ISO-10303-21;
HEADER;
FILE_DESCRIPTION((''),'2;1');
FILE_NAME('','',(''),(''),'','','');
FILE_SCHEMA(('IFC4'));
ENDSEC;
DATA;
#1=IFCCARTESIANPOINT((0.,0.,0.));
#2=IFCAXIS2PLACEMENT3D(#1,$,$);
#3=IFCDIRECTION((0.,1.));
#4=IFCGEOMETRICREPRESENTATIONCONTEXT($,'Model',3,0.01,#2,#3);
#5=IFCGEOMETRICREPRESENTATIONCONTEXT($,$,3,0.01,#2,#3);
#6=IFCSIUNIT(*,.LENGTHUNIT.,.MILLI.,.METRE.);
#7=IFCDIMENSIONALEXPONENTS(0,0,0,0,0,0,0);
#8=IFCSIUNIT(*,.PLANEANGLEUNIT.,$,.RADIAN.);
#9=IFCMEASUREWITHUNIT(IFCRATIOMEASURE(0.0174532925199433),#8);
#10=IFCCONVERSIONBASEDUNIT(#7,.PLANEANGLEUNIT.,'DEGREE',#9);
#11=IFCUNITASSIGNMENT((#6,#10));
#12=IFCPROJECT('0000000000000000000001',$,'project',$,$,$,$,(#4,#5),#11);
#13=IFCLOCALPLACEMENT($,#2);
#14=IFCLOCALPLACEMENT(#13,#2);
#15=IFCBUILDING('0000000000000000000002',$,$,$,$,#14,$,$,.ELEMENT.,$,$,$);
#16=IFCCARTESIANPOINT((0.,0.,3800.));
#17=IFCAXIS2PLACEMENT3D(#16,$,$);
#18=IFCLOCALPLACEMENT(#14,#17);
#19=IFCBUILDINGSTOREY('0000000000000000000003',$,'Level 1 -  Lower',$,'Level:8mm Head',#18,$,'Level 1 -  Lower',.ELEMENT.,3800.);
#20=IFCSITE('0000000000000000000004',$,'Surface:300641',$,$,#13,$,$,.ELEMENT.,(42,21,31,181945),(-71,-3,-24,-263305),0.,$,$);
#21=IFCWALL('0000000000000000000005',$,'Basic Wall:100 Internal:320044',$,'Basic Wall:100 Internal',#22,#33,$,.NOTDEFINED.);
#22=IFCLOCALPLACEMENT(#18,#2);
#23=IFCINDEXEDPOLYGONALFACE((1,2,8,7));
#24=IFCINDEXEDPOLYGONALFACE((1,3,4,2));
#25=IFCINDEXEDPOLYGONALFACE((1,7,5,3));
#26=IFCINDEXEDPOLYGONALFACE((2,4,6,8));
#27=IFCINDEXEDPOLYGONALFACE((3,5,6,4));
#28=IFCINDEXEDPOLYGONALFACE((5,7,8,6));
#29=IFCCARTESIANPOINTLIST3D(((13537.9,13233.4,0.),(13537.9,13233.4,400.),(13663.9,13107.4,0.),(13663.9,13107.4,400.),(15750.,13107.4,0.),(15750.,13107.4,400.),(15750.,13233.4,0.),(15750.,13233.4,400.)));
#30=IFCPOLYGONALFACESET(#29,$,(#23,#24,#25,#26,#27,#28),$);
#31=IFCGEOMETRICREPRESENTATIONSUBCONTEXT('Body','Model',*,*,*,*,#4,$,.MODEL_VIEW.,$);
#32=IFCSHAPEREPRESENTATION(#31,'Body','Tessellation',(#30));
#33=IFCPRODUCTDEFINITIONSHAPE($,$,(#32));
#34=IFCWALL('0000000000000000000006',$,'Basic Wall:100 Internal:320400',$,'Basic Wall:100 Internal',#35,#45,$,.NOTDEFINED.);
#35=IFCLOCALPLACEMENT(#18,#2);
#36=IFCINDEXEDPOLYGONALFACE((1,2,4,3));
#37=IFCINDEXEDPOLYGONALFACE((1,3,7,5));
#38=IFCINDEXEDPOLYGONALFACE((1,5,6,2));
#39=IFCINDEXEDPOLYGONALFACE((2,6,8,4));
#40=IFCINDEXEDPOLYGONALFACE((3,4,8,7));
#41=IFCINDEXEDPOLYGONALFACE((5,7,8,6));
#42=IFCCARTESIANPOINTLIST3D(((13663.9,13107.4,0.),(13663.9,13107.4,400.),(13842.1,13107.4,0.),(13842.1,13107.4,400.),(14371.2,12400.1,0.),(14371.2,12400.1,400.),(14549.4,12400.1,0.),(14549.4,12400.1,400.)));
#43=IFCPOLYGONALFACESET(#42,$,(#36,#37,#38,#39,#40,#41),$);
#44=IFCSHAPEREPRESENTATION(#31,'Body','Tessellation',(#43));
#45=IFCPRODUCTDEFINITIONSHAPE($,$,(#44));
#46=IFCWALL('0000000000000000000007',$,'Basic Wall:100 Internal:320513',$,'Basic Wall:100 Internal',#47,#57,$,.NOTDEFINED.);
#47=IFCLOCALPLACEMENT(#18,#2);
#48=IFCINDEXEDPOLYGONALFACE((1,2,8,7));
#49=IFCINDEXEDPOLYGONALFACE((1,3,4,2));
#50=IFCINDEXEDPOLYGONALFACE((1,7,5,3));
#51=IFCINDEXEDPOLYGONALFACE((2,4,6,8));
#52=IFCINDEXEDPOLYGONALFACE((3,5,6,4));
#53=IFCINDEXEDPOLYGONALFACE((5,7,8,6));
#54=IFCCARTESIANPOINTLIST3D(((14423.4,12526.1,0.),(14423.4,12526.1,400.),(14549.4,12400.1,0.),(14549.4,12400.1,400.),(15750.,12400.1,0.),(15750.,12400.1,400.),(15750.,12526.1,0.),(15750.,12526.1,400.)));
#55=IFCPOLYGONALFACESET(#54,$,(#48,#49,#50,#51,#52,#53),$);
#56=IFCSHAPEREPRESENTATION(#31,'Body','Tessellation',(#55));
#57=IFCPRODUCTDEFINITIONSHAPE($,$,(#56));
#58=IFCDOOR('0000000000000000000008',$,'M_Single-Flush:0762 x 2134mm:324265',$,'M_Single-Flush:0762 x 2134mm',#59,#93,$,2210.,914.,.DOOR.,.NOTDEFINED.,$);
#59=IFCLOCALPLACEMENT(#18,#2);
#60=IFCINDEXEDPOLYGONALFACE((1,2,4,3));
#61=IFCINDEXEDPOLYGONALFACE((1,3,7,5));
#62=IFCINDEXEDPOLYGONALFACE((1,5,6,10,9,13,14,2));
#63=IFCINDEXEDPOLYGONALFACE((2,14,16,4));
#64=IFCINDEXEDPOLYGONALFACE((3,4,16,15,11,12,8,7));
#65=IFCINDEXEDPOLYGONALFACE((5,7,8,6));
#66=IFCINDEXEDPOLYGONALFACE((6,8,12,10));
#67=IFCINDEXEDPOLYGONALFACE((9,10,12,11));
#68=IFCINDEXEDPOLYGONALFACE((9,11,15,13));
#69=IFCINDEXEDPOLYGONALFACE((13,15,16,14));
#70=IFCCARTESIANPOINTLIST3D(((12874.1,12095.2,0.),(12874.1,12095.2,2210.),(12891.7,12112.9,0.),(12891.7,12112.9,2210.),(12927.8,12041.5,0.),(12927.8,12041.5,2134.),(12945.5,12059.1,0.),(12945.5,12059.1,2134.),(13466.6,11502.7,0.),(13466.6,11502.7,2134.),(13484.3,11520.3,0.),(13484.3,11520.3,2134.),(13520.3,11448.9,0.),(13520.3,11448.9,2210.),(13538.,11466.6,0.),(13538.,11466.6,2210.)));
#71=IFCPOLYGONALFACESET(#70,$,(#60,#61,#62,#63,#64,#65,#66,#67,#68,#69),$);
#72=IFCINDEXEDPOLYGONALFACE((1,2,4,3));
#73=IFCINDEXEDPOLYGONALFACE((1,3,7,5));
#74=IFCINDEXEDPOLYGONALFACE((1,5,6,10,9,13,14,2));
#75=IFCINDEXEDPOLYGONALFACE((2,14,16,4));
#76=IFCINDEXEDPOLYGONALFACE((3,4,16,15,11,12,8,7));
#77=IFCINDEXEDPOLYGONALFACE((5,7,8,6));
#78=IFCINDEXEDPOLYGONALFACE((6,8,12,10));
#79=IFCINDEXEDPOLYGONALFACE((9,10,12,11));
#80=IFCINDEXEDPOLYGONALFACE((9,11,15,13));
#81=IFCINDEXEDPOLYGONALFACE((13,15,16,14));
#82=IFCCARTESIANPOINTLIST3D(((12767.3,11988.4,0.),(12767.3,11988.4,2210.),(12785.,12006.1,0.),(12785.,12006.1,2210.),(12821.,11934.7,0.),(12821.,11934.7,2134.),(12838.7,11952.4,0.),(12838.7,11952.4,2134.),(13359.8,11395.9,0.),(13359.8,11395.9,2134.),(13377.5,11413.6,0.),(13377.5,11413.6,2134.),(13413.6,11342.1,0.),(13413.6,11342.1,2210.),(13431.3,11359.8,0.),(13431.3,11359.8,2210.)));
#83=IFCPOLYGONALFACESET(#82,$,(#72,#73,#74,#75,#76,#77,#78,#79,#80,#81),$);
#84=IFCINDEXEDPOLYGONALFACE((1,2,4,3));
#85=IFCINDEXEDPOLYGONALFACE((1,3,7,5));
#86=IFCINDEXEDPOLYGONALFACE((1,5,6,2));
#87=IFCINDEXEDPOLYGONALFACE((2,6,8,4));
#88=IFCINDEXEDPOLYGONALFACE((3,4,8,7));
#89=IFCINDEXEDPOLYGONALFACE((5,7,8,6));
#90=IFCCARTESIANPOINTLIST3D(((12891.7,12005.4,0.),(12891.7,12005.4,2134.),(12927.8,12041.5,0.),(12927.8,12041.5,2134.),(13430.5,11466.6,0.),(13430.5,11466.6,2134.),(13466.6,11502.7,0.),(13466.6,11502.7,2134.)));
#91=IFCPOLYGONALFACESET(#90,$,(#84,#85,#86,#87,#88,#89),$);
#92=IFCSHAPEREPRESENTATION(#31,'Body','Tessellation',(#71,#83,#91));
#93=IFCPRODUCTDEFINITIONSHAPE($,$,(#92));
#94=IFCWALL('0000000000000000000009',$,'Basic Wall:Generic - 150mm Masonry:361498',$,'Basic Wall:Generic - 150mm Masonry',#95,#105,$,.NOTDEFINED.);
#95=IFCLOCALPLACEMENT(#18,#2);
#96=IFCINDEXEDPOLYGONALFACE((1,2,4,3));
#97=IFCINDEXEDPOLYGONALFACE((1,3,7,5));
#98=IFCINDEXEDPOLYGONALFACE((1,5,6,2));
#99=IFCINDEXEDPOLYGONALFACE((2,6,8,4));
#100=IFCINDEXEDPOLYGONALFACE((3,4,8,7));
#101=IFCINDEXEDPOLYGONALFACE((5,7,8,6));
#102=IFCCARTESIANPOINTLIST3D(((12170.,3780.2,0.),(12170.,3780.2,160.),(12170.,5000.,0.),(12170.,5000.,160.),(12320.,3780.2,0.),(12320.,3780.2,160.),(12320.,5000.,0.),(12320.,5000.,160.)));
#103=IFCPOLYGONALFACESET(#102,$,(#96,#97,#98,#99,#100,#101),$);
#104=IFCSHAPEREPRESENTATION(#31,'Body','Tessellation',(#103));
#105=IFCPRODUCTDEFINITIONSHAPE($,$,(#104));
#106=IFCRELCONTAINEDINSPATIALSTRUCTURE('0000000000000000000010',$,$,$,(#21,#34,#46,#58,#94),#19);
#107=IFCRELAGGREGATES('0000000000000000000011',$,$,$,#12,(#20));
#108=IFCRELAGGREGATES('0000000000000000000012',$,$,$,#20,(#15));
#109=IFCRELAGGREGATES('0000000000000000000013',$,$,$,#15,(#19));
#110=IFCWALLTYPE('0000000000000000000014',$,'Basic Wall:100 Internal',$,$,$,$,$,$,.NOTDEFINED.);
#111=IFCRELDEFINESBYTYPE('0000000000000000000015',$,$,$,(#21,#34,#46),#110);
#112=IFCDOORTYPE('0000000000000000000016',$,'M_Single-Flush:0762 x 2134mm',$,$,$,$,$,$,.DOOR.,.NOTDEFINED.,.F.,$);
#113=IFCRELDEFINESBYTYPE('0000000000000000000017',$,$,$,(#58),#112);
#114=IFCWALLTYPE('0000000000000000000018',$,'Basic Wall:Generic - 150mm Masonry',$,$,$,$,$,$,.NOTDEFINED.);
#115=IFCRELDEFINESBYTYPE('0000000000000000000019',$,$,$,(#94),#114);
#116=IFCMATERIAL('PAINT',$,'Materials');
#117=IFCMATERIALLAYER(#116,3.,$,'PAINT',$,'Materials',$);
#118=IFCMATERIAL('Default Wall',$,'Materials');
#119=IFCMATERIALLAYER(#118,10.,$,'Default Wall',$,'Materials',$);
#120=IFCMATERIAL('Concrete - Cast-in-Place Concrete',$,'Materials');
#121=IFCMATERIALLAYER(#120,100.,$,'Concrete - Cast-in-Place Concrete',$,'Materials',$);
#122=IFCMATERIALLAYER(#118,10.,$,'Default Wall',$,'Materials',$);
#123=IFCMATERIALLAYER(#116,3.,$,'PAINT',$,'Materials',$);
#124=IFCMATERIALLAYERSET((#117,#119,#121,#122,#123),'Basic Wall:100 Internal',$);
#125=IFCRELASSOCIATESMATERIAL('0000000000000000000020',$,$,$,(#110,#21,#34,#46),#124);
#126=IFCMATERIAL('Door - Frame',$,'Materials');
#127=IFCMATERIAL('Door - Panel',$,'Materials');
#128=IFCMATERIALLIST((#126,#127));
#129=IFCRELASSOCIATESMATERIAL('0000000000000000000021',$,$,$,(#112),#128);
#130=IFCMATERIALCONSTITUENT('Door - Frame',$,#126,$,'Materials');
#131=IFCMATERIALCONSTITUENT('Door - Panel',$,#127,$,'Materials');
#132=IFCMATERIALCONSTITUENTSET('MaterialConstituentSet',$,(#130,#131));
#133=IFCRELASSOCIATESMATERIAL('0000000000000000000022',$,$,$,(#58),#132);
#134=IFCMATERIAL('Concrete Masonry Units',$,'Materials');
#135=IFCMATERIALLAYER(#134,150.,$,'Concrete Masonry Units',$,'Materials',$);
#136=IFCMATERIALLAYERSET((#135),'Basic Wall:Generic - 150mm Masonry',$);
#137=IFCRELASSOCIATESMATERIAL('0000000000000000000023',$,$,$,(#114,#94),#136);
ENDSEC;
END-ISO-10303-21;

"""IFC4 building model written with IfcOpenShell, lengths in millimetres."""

from ifc_helpers import new_model, entity, si_unit, converted_unit, direction, frame, frame_2d, origin, origin_2d_with_axis, place, context, subcontext, project, spatial, polyline, rectangle, outline, extrude, clip, halfspace, source, transform, mapped, material, material_list, layer, layer_set, layer_usage, constituent, constituent_set, type_object, type_shapes, element, save


model = new_model("IFC4")

# Units and contexts
model_context = context("Model", 3, precision=0.01, world=origin(), true_north=direction((0.0, 1.0)))
context_of_model = context(None, 3, precision=0.01, world=origin(), true_north=direction((0.0, 1.0)))
body_context = subcontext(model_context, "Body", "Model", "MODEL_VIEW")
ifc_project = project(units=[si_unit("LENGTHUNIT", "METRE", prefix="MILLI"), converted_unit("PLANEANGLEUNIT", "DEGREE", entity("IfcRatioMeasure", 0.0174532925199433), si_unit("PLANEANGLEUNIT", "RADIAN"), dimensions=[0, 0, 0, 0, 0, 0, 0])], contexts=[model_context, context_of_model])

# Site, building, storey
site_placement = place(None, origin())
site = spatial("IfcSite", under=ifc_project, at=site_placement, Name="Surface:300641", CompositionType="ELEMENT", RefLatitude=(42, 21, 31, 181945), RefLongitude=(-71, -3, -24, -263305), RefElevation=0.0)
building_placement = place(site_placement, origin())
building = spatial("IfcBuilding", under=site, at=building_placement, CompositionType="ELEMENT")
storey_placement = place(building_placement, frame((0.0, 0.0, 3800.0)))
storey = spatial("IfcBuildingStorey", under=building, at=storey_placement, Name="Level 1 -  Lower", ObjectType="Level:8mm Head", LongName="Level 1 -  Lower", CompositionType="ELEMENT", Elevation=3800.0)

# Shared definitions
ifc_material_1 = material(Name="Concrete - Cast-in-Place Concrete", Category="Materials")

# Shared definitions
ifc_material_2 = material(Name="PAINT", Category="Materials")
ifc_material_3 = material(Name="Default Wall", Category="Materials")

# Walls
ifc_layer_1 = layer(ifc_material_2, 3.0, Name="PAINT", Category="Materials")
ifc_layer_2 = layer(ifc_material_3, 10.0, Name="Default Wall", Category="Materials")
ifc_layer_3 = layer(ifc_material_1, 100.0, Name="Concrete - Cast-in-Place Concrete", Category="Materials")
ifc_layer_4 = layer(ifc_material_3, 10.0, Name="Default Wall", Category="Materials")
ifc_layer_5 = layer(ifc_material_2, 3.0, Name="PAINT", Category="Materials")
ifc_layer_set_1 = layer_set([ifc_layer_1, ifc_layer_2, ifc_layer_3, ifc_layer_4, ifc_layer_5], Name="Basic Wall:100 Internal")
ifc_layer_usage_1 = layer_usage(ifc_layer_set_1, "AXIS2", "NEGATIVE", 63.0)
wall_type_1 = type_object("IfcWallType", Name="Basic Wall:100 Internal", PredefinedType="NOTDEFINED", material=ifc_layer_set_1)
wall_1_placement = place(storey_placement, frame((15750.0, 13170.4, 0.0), z_axis=(0.0, 0.0, 1.0), x_axis=(-1.0, 0.0, 0.0)))
element("IfcWall", 1, at=wall_1_placement, inside=storey, type_object=wall_type_1, material=ifc_layer_usage_1, Name="Basic Wall:100 Internal:320044", ObjectType="Basic Wall:100 Internal", PredefinedType="NOTDEFINED", context=body_context, shape_type="Clipping", body=[
    clip(extrude(outline(polyline([(2212.1, -63.0), (2086.1, 63.0), (1907.9, 63.0), (0.0, 63.0), (0.0, -63.0), (2212.1, -63.0)])), origin(), (0.0, 0.0, 1.0), 400.0), halfspace(origin(), True)),
])
ifc_layer_usage_2 = layer_usage(ifc_layer_set_1, "AXIS2", "NEGATIVE", 63.0)
wall_2_placement = place(storey_placement, frame((13708.5, 13152.0, 0.0), z_axis=(0.0, 0.0, 1.0), x_axis=(0.707107, -0.707107, 0.0)))
element("IfcWall", 2, at=wall_2_placement, inside=storey, type_object=wall_type_1, material=ifc_layer_usage_2, Name="Basic Wall:100 Internal:320400", ObjectType="Basic Wall:100 Internal", PredefinedType="NOTDEFINED", context=body_context, shape_type="Clipping", body=[
    clip(extrude(outline(polyline([(1000.3, -63.0), (1126.3, 63.0), (948.1, 63.0), (126.0, 63.0), (0.0, -63.0), (1000.3, -63.0)])), origin(), (0.0, 0.0, 1.0), 400.0), halfspace(origin(), True)),
])
ifc_layer_usage_3 = layer_usage(ifc_layer_set_1, "AXIS2", "NEGATIVE", 63.0)
wall_3_placement = place(storey_placement, frame((14423.4, 12463.1, 0.0)))
element("IfcWall", 3, at=wall_3_placement, inside=storey, type_object=wall_type_1, material=ifc_layer_usage_3, Name="Basic Wall:100 Internal:320513", ObjectType="Basic Wall:100 Internal", PredefinedType="NOTDEFINED", context=body_context, shape_type="Clipping", body=[
    clip(extrude(outline(polyline([(1326.6, -63.0), (1326.6, 63.0), (0.0, 63.0), (126.0, -63.0), (1326.6, -63.0)])), origin(), (0.0, 0.0, 1.0), 400.0), halfspace(origin(), True)),
])

# Door
ifc_material_4 = material(Name="Door - Frame", Category="Materials")
ifc_constituent_1 = constituent(ifc_material_4, Name="Door - Frame", Category="Materials")
ifc_material_5 = material(Name="Door - Panel", Category="Materials")
ifc_constituent_2 = constituent(ifc_material_5, Name="Door - Panel", Category="Materials")
ifc_constituent_set = constituent_set(constituents=[ifc_constituent_1, ifc_constituent_2], Name="MaterialConstituentSet")
ifc_material_list = material_list([ifc_material_4, ifc_material_5])
door_type = type_object("IfcDoorType", Name="M_Single-Flush:0762 x 2134mm", OperationType="NOTDEFINED", ParameterTakesPrecedence=False, PredefinedType="DOOR", material=ifc_material_list)
shared_shape_1 = source(origin(), body_context, "Body", "SweptSolid", [
    extrude(outline(polyline([(-457.0, -1124.0), (457.0, -1124.0), (457.0, 1086.0), (381.0, 1086.0), (381.0, -1048.0), (-381.0, -1048.0), (-381.0, 1086.0), (-457.0, 1086.0), (-457.0, -1124.0)])), frame((381.0, 126.0, 1086.0), z_axis=(0.0, 1.0, 0.0), x_axis=(1.0, 0.0, 0.0)), (0.0, 0.0, 1.0), 25.0),
    extrude(outline(polyline([(-1124.0, -457.0), (1086.0, -457.0), (1086.0, -381.0), (-1048.0, -381.0), (-1048.0, 381.0), (1086.0, 381.0), (1086.0, 457.0), (-1124.0, 457.0), (-1124.0, -457.0)])), frame((381.0, -25.0, 1086.0), z_axis=(0.0, 1.0, 0.0), x_axis=(0.0, 0.0, -1.0)), (0.0, 0.0, 1.0), 25.0),
    extrude(rectangle(XDim=51.0, YDim=762.0, at=origin_2d_with_axis()), frame((381.0, 100.5, 0.0), z_axis=(0.0, 0.0, 1.0), x_axis=(0.0, 1.0, 0.0)), (0.0, 0.0, 1.0), 2134.0),
])
type_shapes(door_type, [shared_shape_1])
door_placement = place(storey_placement, frame((12838.7, 11952.4, 0.0), z_axis=(0.0, 0.0, 1.0), x_axis=(0.707107, -0.707107, 0.0)))
element("IfcDoor", 4, at=door_placement, inside=storey, type_object=door_type, material=ifc_constituent_set, Name="M_Single-Flush:0762 x 2134mm:324265", ObjectType="M_Single-Flush:0762 x 2134mm", OperationType="NOTDEFINED", OverallHeight=2210.0, OverallWidth=914.0, PredefinedType="DOOR", context=body_context, shape_type="MappedRepresentation", body=[
    mapped(shared_shape_1, transform((0.0, 0.0, 0.0), scale=1.0)),
])

# Wall
ifc_material_6 = material(Name="Concrete Masonry Units", Category="Materials")
ifc_layer_6 = layer(ifc_material_6, 150.0, Name="Concrete Masonry Units", Category="Materials")
ifc_layer_set_2 = layer_set([ifc_layer_6], Name="Basic Wall:Generic - 150mm Masonry")
ifc_layer_usage_4 = layer_usage(ifc_layer_set_2, "AXIS2", "NEGATIVE", 75.0)
wall_type_2 = type_object("IfcWallType", Name="Basic Wall:Generic - 150mm Masonry", PredefinedType="NOTDEFINED", material=ifc_layer_set_2)
wall_4_placement = place(storey_placement, frame((12245.0, 5000.0, 0.0), z_axis=(0.0, 0.0, 1.0), x_axis=(0.0, -1.0, 0.0)))
element("IfcWall", 5, at=wall_4_placement, inside=storey, type_object=wall_type_2, material=ifc_layer_usage_4, Name="Basic Wall:Generic - 150mm Masonry:361498", ObjectType="Basic Wall:Generic - 150mm Masonry", PredefinedType="NOTDEFINED", context=body_context, shape_type="Clipping", body=[
    clip(extrude(rectangle(XDim=1219.8, YDim=150.0, at=frame_2d((609.9, 0.0), x_axis=(-1.0, 0.0))), origin(), (0.0, 0.0, 1.0), 160.0), halfspace(frame((0.0, 0.0, -3200.0)), True)),
])

save(model, "model.ifc")
